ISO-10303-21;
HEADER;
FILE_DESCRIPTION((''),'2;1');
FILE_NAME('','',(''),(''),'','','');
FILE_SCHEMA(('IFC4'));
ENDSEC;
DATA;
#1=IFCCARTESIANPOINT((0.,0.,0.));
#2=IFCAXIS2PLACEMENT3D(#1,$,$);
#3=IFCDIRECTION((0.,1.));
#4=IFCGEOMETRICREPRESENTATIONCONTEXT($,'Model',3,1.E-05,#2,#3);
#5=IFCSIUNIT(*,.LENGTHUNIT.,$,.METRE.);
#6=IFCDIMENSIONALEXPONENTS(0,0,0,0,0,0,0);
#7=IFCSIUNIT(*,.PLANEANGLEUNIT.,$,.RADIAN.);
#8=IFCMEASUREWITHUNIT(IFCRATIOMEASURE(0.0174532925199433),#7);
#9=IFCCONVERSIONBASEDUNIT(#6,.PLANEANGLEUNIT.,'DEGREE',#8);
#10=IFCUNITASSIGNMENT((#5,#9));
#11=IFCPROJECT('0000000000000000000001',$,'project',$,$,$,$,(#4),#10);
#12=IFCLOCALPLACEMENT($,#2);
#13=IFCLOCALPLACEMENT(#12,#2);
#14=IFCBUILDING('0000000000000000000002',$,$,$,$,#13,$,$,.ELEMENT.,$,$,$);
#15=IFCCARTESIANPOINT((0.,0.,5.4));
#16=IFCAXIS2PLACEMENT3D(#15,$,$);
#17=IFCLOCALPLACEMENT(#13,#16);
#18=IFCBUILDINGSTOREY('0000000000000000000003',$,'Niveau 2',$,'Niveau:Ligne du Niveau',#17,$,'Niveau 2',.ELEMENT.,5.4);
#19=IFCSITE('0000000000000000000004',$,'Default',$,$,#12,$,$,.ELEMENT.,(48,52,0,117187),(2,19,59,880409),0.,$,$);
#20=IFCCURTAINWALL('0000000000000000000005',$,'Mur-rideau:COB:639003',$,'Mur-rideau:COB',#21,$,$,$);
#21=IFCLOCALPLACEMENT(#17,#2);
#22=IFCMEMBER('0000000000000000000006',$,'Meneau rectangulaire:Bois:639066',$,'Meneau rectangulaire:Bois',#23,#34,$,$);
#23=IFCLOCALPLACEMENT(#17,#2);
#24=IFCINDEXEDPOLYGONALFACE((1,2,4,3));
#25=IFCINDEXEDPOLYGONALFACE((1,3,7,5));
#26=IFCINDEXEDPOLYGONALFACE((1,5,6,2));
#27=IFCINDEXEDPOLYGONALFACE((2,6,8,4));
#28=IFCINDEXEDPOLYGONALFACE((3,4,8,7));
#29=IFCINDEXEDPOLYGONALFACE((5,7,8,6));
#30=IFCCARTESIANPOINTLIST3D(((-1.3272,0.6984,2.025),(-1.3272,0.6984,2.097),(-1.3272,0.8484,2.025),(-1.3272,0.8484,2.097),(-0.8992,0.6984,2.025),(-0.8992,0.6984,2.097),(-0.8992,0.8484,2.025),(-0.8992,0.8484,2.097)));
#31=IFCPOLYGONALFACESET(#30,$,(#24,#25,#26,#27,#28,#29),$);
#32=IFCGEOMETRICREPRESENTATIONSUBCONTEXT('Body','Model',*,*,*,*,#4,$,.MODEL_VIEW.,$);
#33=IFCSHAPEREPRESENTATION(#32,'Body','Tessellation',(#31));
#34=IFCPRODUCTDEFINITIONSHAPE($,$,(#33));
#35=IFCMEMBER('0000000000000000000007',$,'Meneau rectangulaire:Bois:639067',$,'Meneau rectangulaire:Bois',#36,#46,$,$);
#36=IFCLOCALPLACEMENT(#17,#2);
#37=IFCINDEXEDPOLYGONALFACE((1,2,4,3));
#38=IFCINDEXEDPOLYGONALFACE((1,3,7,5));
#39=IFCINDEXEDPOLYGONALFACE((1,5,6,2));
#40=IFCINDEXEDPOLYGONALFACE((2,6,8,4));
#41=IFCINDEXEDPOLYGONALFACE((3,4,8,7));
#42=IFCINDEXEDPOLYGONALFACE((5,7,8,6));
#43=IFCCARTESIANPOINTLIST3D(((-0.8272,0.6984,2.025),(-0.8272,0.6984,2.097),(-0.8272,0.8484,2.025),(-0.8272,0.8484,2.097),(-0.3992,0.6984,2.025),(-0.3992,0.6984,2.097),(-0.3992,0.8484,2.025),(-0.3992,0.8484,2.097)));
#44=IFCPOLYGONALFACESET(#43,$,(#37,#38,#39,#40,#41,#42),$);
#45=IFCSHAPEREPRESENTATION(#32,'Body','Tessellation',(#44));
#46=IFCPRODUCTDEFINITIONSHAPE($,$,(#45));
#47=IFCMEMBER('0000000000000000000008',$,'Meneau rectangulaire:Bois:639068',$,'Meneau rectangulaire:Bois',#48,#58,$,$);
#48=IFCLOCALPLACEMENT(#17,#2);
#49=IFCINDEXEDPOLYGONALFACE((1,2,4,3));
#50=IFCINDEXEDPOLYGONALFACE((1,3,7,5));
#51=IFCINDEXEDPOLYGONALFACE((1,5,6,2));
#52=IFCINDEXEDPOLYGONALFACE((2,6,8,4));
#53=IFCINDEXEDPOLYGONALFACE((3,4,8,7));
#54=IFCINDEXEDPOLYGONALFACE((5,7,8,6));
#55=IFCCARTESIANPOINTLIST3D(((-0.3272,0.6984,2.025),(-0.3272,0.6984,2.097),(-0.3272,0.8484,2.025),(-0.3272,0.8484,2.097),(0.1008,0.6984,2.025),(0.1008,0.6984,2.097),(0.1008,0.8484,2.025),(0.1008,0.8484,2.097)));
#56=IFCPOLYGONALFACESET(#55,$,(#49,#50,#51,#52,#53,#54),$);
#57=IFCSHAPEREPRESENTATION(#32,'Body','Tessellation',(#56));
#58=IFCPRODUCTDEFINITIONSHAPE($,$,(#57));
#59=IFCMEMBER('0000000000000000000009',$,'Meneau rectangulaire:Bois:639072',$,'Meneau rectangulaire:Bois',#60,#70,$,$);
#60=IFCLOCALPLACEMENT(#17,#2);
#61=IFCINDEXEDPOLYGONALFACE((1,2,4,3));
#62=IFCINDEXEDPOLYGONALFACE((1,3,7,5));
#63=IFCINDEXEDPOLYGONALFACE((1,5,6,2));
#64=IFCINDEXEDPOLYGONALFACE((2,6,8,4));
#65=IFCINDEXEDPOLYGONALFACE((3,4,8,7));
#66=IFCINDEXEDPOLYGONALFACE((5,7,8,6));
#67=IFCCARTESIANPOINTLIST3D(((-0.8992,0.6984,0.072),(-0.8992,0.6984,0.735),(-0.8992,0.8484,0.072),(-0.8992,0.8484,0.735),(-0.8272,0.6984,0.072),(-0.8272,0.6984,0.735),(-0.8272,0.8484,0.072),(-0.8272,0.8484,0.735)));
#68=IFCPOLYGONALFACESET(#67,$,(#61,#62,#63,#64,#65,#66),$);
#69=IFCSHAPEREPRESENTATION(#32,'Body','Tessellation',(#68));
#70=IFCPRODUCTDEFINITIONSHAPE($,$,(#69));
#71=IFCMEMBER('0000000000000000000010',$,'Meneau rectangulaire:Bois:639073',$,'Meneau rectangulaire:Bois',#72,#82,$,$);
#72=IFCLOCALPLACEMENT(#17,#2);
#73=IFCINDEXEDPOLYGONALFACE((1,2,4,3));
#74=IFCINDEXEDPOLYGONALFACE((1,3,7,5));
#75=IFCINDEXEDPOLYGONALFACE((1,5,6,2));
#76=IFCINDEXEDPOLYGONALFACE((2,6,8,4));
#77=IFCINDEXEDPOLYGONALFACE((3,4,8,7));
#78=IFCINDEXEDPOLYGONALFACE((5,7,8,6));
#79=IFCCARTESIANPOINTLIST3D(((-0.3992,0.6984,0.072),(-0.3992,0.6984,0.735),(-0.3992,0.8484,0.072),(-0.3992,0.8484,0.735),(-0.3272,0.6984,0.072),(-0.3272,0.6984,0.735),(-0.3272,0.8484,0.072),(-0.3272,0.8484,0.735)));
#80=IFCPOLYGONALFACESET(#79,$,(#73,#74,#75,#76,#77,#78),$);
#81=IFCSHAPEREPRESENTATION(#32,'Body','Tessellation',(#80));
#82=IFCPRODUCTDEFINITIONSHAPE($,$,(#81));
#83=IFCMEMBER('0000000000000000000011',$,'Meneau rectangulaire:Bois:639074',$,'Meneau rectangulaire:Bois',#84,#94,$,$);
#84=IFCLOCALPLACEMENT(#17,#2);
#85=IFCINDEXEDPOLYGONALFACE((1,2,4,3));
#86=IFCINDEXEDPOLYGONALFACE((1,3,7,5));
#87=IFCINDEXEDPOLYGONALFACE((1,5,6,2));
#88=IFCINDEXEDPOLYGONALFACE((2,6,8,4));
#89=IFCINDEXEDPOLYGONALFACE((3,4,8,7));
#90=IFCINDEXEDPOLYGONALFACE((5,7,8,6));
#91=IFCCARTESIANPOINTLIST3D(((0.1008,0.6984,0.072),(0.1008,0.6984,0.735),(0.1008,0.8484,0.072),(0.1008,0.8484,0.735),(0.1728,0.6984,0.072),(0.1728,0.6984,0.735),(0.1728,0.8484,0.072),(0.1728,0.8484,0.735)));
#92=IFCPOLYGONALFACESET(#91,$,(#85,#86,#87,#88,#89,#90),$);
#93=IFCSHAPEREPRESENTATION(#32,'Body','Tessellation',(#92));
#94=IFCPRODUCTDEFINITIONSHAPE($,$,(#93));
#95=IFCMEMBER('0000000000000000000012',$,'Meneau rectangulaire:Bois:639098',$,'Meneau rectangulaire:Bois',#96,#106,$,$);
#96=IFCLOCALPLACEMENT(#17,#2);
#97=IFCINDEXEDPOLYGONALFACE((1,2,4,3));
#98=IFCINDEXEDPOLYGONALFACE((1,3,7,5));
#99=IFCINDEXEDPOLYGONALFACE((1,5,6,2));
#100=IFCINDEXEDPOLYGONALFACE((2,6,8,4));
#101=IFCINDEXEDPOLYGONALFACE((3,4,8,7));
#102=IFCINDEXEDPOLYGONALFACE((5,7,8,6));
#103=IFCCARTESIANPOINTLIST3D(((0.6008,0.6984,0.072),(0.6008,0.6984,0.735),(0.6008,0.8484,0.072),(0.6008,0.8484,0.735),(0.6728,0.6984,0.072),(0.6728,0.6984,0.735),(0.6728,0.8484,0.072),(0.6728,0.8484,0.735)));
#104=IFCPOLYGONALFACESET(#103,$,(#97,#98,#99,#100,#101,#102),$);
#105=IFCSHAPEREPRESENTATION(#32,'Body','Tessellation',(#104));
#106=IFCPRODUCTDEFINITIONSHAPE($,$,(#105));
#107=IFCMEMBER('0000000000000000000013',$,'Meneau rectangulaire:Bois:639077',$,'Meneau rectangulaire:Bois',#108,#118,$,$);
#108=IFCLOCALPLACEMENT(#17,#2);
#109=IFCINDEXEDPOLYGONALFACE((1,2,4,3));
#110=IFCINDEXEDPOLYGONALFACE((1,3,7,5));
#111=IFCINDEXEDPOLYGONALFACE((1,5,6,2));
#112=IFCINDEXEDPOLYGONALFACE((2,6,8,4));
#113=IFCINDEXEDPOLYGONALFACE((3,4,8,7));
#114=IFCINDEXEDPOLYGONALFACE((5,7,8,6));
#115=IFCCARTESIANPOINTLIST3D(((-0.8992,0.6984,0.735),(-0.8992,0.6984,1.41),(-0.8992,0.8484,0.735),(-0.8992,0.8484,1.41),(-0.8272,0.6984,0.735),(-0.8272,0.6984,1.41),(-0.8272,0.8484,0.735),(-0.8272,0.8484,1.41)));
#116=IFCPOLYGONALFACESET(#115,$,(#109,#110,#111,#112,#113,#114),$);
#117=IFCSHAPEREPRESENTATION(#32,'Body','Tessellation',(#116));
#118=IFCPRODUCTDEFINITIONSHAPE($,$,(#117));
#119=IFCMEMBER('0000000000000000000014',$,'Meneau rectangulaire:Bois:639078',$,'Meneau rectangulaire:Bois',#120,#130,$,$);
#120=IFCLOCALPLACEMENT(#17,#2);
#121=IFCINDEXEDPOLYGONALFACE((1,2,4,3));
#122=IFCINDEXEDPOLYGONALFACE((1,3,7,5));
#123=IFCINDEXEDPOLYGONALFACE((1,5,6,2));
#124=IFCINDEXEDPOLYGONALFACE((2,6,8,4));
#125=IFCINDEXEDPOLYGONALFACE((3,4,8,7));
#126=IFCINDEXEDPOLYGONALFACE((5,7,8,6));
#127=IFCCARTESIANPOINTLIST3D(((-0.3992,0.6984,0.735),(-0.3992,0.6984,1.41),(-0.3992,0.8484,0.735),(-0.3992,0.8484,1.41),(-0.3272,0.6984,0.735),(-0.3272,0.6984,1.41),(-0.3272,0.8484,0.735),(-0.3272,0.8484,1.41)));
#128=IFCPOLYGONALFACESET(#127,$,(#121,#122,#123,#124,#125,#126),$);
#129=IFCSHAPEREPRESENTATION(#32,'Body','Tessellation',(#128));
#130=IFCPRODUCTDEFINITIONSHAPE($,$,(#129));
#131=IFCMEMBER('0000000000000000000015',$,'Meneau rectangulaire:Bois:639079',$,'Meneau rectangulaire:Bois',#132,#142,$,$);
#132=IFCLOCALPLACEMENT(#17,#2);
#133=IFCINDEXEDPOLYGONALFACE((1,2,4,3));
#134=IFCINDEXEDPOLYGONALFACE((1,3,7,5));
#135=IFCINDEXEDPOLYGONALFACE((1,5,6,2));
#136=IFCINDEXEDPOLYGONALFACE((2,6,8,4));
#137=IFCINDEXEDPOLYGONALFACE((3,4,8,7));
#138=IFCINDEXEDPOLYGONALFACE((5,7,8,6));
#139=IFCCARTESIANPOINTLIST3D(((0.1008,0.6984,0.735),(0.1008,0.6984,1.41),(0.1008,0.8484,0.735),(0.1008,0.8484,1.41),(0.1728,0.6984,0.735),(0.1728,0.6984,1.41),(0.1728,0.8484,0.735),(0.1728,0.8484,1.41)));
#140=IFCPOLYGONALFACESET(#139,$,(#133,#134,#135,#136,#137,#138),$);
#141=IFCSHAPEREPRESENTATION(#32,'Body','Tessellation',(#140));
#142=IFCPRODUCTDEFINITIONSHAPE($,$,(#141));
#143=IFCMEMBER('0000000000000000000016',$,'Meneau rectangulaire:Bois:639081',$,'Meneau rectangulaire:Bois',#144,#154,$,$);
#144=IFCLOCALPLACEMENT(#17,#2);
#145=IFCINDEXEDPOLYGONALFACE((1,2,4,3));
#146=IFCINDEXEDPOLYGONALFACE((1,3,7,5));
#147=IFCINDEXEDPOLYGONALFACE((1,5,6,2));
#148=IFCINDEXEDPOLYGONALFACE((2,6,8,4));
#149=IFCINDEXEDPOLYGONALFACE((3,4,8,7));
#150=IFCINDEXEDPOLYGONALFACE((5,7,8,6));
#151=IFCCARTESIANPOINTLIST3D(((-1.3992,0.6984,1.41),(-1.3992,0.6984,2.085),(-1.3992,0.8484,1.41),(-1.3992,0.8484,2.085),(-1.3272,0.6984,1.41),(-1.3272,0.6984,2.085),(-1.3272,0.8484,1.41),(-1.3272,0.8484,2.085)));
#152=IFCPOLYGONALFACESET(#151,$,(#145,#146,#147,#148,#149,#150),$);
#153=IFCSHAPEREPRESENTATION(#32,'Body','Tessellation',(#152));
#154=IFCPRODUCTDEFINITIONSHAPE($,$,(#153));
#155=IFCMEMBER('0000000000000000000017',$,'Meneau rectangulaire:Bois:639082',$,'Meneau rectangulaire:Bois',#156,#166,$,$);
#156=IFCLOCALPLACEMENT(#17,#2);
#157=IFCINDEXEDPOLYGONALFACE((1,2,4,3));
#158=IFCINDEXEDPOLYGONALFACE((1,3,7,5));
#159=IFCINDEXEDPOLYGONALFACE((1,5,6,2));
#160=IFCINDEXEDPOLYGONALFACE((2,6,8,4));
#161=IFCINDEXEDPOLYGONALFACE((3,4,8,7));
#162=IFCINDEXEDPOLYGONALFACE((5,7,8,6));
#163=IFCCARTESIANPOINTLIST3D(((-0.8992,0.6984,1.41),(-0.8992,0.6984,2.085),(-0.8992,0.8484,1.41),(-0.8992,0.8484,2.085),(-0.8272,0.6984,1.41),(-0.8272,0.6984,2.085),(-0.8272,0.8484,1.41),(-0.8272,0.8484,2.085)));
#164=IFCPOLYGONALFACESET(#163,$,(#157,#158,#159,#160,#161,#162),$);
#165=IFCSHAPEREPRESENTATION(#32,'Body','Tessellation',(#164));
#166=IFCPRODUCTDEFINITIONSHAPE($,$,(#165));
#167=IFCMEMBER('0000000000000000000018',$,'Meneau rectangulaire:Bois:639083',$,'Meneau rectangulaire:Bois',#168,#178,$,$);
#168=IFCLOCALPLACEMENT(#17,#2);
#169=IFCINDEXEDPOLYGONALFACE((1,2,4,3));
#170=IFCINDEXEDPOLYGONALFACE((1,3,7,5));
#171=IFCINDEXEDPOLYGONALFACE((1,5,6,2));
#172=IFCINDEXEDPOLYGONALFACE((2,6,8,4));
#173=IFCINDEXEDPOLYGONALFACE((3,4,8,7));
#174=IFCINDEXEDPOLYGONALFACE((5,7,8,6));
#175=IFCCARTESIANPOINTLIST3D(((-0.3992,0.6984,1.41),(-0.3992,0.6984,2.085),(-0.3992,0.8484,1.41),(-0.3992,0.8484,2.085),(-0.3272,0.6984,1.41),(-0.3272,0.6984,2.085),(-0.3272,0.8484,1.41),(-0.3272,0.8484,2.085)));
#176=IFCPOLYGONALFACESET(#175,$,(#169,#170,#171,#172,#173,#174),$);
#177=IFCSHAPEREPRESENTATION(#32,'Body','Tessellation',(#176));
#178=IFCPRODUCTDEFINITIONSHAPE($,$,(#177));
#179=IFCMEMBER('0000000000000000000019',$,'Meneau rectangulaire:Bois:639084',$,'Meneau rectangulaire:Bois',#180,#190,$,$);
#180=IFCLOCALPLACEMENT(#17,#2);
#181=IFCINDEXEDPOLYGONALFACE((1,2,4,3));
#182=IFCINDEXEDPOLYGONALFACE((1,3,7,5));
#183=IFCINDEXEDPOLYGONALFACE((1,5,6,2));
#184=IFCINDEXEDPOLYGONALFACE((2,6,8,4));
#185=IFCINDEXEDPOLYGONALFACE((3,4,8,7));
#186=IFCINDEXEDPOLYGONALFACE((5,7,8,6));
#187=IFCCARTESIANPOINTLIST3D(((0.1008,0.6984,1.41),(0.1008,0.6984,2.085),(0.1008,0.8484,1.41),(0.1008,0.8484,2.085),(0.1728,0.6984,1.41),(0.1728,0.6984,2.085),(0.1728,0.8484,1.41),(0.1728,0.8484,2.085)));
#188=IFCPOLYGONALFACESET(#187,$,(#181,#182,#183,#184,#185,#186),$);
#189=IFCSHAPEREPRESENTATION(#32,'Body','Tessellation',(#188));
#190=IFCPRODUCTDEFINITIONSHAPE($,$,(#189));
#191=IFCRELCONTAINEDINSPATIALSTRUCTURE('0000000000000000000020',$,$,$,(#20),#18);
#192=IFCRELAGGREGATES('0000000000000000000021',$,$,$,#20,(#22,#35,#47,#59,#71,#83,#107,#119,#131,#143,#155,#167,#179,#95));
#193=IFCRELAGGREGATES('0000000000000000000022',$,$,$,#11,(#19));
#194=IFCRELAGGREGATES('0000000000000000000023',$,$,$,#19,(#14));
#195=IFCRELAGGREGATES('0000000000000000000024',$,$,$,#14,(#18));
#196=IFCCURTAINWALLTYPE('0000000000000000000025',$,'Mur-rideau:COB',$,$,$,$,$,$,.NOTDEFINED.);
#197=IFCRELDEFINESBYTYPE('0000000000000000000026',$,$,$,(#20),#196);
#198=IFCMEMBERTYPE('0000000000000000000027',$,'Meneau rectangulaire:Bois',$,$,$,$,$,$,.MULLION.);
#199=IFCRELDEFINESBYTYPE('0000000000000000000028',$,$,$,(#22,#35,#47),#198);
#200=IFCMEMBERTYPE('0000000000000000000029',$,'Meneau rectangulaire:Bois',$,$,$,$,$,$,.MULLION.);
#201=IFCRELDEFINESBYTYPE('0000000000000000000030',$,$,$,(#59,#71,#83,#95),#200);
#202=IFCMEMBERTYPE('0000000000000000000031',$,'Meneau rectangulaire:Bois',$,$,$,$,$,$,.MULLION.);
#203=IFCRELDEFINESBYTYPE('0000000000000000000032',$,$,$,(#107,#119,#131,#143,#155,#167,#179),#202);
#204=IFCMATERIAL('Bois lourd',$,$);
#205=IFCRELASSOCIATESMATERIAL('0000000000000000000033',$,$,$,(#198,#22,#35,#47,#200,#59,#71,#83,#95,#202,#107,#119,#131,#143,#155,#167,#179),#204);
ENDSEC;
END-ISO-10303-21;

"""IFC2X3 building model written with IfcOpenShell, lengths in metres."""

from ifc_helpers import new_model, entity, si_unit, converted_unit, direction, frame, origin, origin_2d_with_axis, place, context, subcontext, project, spatial, rectangle, extrude, source, transform, mapped, material, type_object, type_shapes, element, aggregate, save


model = new_model("IFC2X3")

# Units and contexts
model_context = context("Model", 3, precision=1e-05, world=origin(), true_north=direction((0.0, 1.0)))
body_context = subcontext(model_context, "Body", "Model", "MODEL_VIEW")
ifc_project = project(units=[si_unit("LENGTHUNIT", "METRE"), converted_unit("PLANEANGLEUNIT", "DEGREE", entity("IfcRatioMeasure", 0.0174532925199433), si_unit("PLANEANGLEUNIT", "RADIAN"), dimensions=[0, 0, 0, 0, 0, 0, 0])], contexts=[model_context])

# Site, building, storey
site_placement = place(None, origin())
site = spatial("IfcSite", under=ifc_project, at=site_placement, Name="Default", CompositionType="ELEMENT", RefLatitude=(48, 52, 0, 117187), RefLongitude=(2, 19, 59, 880409), RefElevation=0.0)
building_placement = place(site_placement, origin())
building = spatial("IfcBuilding", under=site, at=building_placement, CompositionType="ELEMENT")
storey_placement = place(building_placement, frame((0.0, 0.0, 5.4)))
storey = spatial("IfcBuildingStorey", under=building, at=storey_placement, Name="Niveau 2", ObjectType="Niveau:Ligne du Niveau", LongName="Niveau 2", CompositionType="ELEMENT", Elevation=5.4)

# Curtain wall, members
curtain_wall_type_1 = type_object("IfcCurtainWallType", Name="Mur-rideau:COB", PredefinedType="NOTDEFINED")
curtain_wall_1_placement = place(storey_placement, frame((0.0, 0.0, -5.4)))
curtain_wall_1 = element("IfcCurtainWall", 1, at=curtain_wall_1_placement, inside=storey, type_object=curtain_wall_type_1, Name="Mur-rideau:COB:639003", ObjectType="Mur-rideau:COB")
ifc_material_1 = material(Name="Bois lourd")
member_type_1 = type_object("IfcMemberType", Name="Meneau rectangulaire:Bois", PredefinedType="MULLION", material=ifc_material_1)
shared_shape_1 = source(origin(), body_context, "Body", "SweptSolid", [
    extrude(rectangle(XDim=0.15, YDim=0.072, at=origin_2d_with_axis()), frame((-0.024, 0.0, -0.428), z_axis=(0.0, 0.0, 1.0), x_axis=(0.0, -1.0, 0.0)), (0.0, 0.0, 1.0), 0.428),
])
type_shapes(member_type_1, [shared_shape_1])
member_1_placement = place(storey_placement, frame((-0.8992, 0.7734, 2.085), z_axis=(1.0, 0.0, 0.0), x_axis=(0.0, 0.0, 1.0)))
member_1 = element("IfcMember", 2, at=member_1_placement, type_object=member_type_1, material=ifc_material_1, Name="Meneau rectangulaire:Bois:639066", ObjectType="Meneau rectangulaire:Bois", context=body_context, shape_type="MappedRepresentation", body=[
    mapped(shared_shape_1, transform((0.0, 0.0, 0.0), scale=1.0)),
])
member_2_placement = place(storey_placement, frame((-0.3992, 0.7734, 2.085), z_axis=(1.0, 0.0, 0.0), x_axis=(0.0, 0.0, 1.0)))
member_2 = element("IfcMember", 3, at=member_2_placement, type_object=member_type_1, material=ifc_material_1, Name="Meneau rectangulaire:Bois:639067", ObjectType="Meneau rectangulaire:Bois", context=body_context, shape_type="MappedRepresentation", body=[
    mapped(shared_shape_1, transform((0.0, 0.0, 0.0), scale=1.0)),
])
member_3_placement = place(storey_placement, frame((0.1008, 0.7734, 2.085), z_axis=(1.0, 0.0, 0.0), x_axis=(0.0, 0.0, 1.0)))
member_3 = element("IfcMember", 4, at=member_3_placement, type_object=member_type_1, material=ifc_material_1, Name="Meneau rectangulaire:Bois:639068", ObjectType="Meneau rectangulaire:Bois", context=body_context, shape_type="MappedRepresentation", body=[
    mapped(shared_shape_1, transform((0.0, 0.0, 0.0), scale=1.0)),
])
member_type_2 = type_object("IfcMemberType", Name="Meneau rectangulaire:Bois", PredefinedType="MULLION", material=ifc_material_1)
shared_shape_2 = source(origin(), body_context, "Body", "SweptSolid", [
    extrude(rectangle(XDim=0.15, YDim=0.072, at=origin_2d_with_axis()), frame((-0.024, 0.0, -0.663), z_axis=(0.0, 0.0, 1.0), x_axis=(0.0, -1.0, 0.0)), (0.0, 0.0, 1.0), 0.663),
])
type_shapes(member_type_2, [shared_shape_2])
member_4_placement = place(storey_placement, frame((-0.8392, 0.7734, 0.072), z_axis=(0.0, 0.0, -1.0), x_axis=(1.0, 0.0, 0.0)))
member_4 = element("IfcMember", 5, at=member_4_placement, type_object=member_type_2, material=ifc_material_1, Name="Meneau rectangulaire:Bois:639072", ObjectType="Meneau rectangulaire:Bois", context=body_context, shape_type="MappedRepresentation", body=[
    mapped(shared_shape_2, transform((0.0, 0.0, 0.0), scale=1.0)),
])
member_5_placement = place(storey_placement, frame((-0.3392, 0.7734, 0.072), z_axis=(0.0, 0.0, -1.0), x_axis=(1.0, 0.0, 0.0)))
member_5 = element("IfcMember", 6, at=member_5_placement, type_object=member_type_2, material=ifc_material_1, Name="Meneau rectangulaire:Bois:639073", ObjectType="Meneau rectangulaire:Bois", context=body_context, shape_type="MappedRepresentation", body=[
    mapped(shared_shape_2, transform((0.0, 0.0, 0.0), scale=1.0)),
])
member_6_placement = place(storey_placement, frame((0.1608, 0.7734, 0.072), z_axis=(0.0, 0.0, -1.0), x_axis=(1.0, 0.0, 0.0)))
member_6 = element("IfcMember", 7, at=member_6_placement, type_object=member_type_2, material=ifc_material_1, Name="Meneau rectangulaire:Bois:639074", ObjectType="Meneau rectangulaire:Bois", context=body_context, shape_type="MappedRepresentation", body=[
    mapped(shared_shape_2, transform((0.0, 0.0, 0.0), scale=1.0)),
])
member_7_placement = place(storey_placement, frame((0.6608, 0.7734, 0.072), z_axis=(0.0, 0.0, -1.0), x_axis=(1.0, 0.0, 0.0)))
member_7 = element("IfcMember", 8, at=member_7_placement, type_object=member_type_2, material=ifc_material_1, Name="Meneau rectangulaire:Bois:639098", ObjectType="Meneau rectangulaire:Bois", context=body_context, shape_type="MappedRepresentation", body=[
    mapped(shared_shape_2, transform((0.0, 0.0, 0.0), scale=1.0)),
])
member_type_3 = type_object("IfcMemberType", Name="Meneau rectangulaire:Bois", PredefinedType="MULLION", material=ifc_material_1)
shared_shape_3 = source(origin(), body_context, "Body", "SweptSolid", [
    extrude(rectangle(XDim=0.15, YDim=0.072, at=origin_2d_with_axis()), frame((-0.024, 0.0, -0.675), z_axis=(0.0, 0.0, 1.0), x_axis=(0.0, -1.0, 0.0)), (0.0, 0.0, 1.0), 0.675),
])
type_shapes(member_type_3, [shared_shape_3])
member_8_placement = place(storey_placement, frame((-0.8392, 0.7734, 0.735), z_axis=(0.0, 0.0, -1.0), x_axis=(1.0, 0.0, 0.0)))
member_8 = element("IfcMember", 9, at=member_8_placement, type_object=member_type_3, material=ifc_material_1, Name="Meneau rectangulaire:Bois:639077", ObjectType="Meneau rectangulaire:Bois", context=body_context, shape_type="MappedRepresentation", body=[
    mapped(shared_shape_3, transform((0.0, 0.0, 0.0), scale=1.0)),
])
member_9_placement = place(storey_placement, frame((-0.3392, 0.7734, 0.735), z_axis=(0.0, 0.0, -1.0), x_axis=(1.0, 0.0, 0.0)))
member_9 = element("IfcMember", 10, at=member_9_placement, type_object=member_type_3, material=ifc_material_1, Name="Meneau rectangulaire:Bois:639078", ObjectType="Meneau rectangulaire:Bois", context=body_context, shape_type="MappedRepresentation", body=[
    mapped(shared_shape_3, transform((0.0, 0.0, 0.0), scale=1.0)),
])
member_10_placement = place(storey_placement, frame((0.1608, 0.7734, 0.735), z_axis=(0.0, 0.0, -1.0), x_axis=(1.0, 0.0, 0.0)))
member_10 = element("IfcMember", 11, at=member_10_placement, type_object=member_type_3, material=ifc_material_1, Name="Meneau rectangulaire:Bois:639079", ObjectType="Meneau rectangulaire:Bois", context=body_context, shape_type="MappedRepresentation", body=[
    mapped(shared_shape_3, transform((0.0, 0.0, 0.0), scale=1.0)),
])
member_11_placement = place(storey_placement, frame((-1.3392, 0.7734, 1.41), z_axis=(0.0, 0.0, -1.0), x_axis=(1.0, 0.0, 0.0)))
member_11 = element("IfcMember", 12, at=member_11_placement, type_object=member_type_3, material=ifc_material_1, Name="Meneau rectangulaire:Bois:639081", ObjectType="Meneau rectangulaire:Bois", context=body_context, shape_type="MappedRepresentation", body=[
    mapped(shared_shape_3, transform((0.0, 0.0, 0.0), scale=1.0)),
])
member_12_placement = place(storey_placement, frame((-0.8392, 0.7734, 1.41), z_axis=(0.0, 0.0, -1.0), x_axis=(1.0, 0.0, 0.0)))
member_12 = element("IfcMember", 13, at=member_12_placement, type_object=member_type_3, material=ifc_material_1, Name="Meneau rectangulaire:Bois:639082", ObjectType="Meneau rectangulaire:Bois", context=body_context, shape_type="MappedRepresentation", body=[
    mapped(shared_shape_3, transform((0.0, 0.0, 0.0), scale=1.0)),
])
member_13_placement = place(storey_placement, frame((-0.3392, 0.7734, 1.41), z_axis=(0.0, 0.0, -1.0), x_axis=(1.0, 0.0, 0.0)))
member_13 = element("IfcMember", 14, at=member_13_placement, type_object=member_type_3, material=ifc_material_1, Name="Meneau rectangulaire:Bois:639083", ObjectType="Meneau rectangulaire:Bois", context=body_context, shape_type="MappedRepresentation", body=[
    mapped(shared_shape_3, transform((0.0, 0.0, 0.0), scale=1.0)),
])
member_14_placement = place(storey_placement, frame((0.1608, 0.7734, 1.41), z_axis=(0.0, 0.0, -1.0), x_axis=(1.0, 0.0, 0.0)))
member_14 = element("IfcMember", 15, at=member_14_placement, type_object=member_type_3, material=ifc_material_1, Name="Meneau rectangulaire:Bois:639084", ObjectType="Meneau rectangulaire:Bois", context=body_context, shape_type="MappedRepresentation", body=[
    mapped(shared_shape_3, transform((0.0, 0.0, 0.0), scale=1.0)),
])
aggregate(curtain_wall_1, [member_1, member_2, member_3, member_4, member_5, member_6, member_8, member_9, member_10, member_11, member_12, member_13, member_14, member_7])

save(model, "model.ifc")
